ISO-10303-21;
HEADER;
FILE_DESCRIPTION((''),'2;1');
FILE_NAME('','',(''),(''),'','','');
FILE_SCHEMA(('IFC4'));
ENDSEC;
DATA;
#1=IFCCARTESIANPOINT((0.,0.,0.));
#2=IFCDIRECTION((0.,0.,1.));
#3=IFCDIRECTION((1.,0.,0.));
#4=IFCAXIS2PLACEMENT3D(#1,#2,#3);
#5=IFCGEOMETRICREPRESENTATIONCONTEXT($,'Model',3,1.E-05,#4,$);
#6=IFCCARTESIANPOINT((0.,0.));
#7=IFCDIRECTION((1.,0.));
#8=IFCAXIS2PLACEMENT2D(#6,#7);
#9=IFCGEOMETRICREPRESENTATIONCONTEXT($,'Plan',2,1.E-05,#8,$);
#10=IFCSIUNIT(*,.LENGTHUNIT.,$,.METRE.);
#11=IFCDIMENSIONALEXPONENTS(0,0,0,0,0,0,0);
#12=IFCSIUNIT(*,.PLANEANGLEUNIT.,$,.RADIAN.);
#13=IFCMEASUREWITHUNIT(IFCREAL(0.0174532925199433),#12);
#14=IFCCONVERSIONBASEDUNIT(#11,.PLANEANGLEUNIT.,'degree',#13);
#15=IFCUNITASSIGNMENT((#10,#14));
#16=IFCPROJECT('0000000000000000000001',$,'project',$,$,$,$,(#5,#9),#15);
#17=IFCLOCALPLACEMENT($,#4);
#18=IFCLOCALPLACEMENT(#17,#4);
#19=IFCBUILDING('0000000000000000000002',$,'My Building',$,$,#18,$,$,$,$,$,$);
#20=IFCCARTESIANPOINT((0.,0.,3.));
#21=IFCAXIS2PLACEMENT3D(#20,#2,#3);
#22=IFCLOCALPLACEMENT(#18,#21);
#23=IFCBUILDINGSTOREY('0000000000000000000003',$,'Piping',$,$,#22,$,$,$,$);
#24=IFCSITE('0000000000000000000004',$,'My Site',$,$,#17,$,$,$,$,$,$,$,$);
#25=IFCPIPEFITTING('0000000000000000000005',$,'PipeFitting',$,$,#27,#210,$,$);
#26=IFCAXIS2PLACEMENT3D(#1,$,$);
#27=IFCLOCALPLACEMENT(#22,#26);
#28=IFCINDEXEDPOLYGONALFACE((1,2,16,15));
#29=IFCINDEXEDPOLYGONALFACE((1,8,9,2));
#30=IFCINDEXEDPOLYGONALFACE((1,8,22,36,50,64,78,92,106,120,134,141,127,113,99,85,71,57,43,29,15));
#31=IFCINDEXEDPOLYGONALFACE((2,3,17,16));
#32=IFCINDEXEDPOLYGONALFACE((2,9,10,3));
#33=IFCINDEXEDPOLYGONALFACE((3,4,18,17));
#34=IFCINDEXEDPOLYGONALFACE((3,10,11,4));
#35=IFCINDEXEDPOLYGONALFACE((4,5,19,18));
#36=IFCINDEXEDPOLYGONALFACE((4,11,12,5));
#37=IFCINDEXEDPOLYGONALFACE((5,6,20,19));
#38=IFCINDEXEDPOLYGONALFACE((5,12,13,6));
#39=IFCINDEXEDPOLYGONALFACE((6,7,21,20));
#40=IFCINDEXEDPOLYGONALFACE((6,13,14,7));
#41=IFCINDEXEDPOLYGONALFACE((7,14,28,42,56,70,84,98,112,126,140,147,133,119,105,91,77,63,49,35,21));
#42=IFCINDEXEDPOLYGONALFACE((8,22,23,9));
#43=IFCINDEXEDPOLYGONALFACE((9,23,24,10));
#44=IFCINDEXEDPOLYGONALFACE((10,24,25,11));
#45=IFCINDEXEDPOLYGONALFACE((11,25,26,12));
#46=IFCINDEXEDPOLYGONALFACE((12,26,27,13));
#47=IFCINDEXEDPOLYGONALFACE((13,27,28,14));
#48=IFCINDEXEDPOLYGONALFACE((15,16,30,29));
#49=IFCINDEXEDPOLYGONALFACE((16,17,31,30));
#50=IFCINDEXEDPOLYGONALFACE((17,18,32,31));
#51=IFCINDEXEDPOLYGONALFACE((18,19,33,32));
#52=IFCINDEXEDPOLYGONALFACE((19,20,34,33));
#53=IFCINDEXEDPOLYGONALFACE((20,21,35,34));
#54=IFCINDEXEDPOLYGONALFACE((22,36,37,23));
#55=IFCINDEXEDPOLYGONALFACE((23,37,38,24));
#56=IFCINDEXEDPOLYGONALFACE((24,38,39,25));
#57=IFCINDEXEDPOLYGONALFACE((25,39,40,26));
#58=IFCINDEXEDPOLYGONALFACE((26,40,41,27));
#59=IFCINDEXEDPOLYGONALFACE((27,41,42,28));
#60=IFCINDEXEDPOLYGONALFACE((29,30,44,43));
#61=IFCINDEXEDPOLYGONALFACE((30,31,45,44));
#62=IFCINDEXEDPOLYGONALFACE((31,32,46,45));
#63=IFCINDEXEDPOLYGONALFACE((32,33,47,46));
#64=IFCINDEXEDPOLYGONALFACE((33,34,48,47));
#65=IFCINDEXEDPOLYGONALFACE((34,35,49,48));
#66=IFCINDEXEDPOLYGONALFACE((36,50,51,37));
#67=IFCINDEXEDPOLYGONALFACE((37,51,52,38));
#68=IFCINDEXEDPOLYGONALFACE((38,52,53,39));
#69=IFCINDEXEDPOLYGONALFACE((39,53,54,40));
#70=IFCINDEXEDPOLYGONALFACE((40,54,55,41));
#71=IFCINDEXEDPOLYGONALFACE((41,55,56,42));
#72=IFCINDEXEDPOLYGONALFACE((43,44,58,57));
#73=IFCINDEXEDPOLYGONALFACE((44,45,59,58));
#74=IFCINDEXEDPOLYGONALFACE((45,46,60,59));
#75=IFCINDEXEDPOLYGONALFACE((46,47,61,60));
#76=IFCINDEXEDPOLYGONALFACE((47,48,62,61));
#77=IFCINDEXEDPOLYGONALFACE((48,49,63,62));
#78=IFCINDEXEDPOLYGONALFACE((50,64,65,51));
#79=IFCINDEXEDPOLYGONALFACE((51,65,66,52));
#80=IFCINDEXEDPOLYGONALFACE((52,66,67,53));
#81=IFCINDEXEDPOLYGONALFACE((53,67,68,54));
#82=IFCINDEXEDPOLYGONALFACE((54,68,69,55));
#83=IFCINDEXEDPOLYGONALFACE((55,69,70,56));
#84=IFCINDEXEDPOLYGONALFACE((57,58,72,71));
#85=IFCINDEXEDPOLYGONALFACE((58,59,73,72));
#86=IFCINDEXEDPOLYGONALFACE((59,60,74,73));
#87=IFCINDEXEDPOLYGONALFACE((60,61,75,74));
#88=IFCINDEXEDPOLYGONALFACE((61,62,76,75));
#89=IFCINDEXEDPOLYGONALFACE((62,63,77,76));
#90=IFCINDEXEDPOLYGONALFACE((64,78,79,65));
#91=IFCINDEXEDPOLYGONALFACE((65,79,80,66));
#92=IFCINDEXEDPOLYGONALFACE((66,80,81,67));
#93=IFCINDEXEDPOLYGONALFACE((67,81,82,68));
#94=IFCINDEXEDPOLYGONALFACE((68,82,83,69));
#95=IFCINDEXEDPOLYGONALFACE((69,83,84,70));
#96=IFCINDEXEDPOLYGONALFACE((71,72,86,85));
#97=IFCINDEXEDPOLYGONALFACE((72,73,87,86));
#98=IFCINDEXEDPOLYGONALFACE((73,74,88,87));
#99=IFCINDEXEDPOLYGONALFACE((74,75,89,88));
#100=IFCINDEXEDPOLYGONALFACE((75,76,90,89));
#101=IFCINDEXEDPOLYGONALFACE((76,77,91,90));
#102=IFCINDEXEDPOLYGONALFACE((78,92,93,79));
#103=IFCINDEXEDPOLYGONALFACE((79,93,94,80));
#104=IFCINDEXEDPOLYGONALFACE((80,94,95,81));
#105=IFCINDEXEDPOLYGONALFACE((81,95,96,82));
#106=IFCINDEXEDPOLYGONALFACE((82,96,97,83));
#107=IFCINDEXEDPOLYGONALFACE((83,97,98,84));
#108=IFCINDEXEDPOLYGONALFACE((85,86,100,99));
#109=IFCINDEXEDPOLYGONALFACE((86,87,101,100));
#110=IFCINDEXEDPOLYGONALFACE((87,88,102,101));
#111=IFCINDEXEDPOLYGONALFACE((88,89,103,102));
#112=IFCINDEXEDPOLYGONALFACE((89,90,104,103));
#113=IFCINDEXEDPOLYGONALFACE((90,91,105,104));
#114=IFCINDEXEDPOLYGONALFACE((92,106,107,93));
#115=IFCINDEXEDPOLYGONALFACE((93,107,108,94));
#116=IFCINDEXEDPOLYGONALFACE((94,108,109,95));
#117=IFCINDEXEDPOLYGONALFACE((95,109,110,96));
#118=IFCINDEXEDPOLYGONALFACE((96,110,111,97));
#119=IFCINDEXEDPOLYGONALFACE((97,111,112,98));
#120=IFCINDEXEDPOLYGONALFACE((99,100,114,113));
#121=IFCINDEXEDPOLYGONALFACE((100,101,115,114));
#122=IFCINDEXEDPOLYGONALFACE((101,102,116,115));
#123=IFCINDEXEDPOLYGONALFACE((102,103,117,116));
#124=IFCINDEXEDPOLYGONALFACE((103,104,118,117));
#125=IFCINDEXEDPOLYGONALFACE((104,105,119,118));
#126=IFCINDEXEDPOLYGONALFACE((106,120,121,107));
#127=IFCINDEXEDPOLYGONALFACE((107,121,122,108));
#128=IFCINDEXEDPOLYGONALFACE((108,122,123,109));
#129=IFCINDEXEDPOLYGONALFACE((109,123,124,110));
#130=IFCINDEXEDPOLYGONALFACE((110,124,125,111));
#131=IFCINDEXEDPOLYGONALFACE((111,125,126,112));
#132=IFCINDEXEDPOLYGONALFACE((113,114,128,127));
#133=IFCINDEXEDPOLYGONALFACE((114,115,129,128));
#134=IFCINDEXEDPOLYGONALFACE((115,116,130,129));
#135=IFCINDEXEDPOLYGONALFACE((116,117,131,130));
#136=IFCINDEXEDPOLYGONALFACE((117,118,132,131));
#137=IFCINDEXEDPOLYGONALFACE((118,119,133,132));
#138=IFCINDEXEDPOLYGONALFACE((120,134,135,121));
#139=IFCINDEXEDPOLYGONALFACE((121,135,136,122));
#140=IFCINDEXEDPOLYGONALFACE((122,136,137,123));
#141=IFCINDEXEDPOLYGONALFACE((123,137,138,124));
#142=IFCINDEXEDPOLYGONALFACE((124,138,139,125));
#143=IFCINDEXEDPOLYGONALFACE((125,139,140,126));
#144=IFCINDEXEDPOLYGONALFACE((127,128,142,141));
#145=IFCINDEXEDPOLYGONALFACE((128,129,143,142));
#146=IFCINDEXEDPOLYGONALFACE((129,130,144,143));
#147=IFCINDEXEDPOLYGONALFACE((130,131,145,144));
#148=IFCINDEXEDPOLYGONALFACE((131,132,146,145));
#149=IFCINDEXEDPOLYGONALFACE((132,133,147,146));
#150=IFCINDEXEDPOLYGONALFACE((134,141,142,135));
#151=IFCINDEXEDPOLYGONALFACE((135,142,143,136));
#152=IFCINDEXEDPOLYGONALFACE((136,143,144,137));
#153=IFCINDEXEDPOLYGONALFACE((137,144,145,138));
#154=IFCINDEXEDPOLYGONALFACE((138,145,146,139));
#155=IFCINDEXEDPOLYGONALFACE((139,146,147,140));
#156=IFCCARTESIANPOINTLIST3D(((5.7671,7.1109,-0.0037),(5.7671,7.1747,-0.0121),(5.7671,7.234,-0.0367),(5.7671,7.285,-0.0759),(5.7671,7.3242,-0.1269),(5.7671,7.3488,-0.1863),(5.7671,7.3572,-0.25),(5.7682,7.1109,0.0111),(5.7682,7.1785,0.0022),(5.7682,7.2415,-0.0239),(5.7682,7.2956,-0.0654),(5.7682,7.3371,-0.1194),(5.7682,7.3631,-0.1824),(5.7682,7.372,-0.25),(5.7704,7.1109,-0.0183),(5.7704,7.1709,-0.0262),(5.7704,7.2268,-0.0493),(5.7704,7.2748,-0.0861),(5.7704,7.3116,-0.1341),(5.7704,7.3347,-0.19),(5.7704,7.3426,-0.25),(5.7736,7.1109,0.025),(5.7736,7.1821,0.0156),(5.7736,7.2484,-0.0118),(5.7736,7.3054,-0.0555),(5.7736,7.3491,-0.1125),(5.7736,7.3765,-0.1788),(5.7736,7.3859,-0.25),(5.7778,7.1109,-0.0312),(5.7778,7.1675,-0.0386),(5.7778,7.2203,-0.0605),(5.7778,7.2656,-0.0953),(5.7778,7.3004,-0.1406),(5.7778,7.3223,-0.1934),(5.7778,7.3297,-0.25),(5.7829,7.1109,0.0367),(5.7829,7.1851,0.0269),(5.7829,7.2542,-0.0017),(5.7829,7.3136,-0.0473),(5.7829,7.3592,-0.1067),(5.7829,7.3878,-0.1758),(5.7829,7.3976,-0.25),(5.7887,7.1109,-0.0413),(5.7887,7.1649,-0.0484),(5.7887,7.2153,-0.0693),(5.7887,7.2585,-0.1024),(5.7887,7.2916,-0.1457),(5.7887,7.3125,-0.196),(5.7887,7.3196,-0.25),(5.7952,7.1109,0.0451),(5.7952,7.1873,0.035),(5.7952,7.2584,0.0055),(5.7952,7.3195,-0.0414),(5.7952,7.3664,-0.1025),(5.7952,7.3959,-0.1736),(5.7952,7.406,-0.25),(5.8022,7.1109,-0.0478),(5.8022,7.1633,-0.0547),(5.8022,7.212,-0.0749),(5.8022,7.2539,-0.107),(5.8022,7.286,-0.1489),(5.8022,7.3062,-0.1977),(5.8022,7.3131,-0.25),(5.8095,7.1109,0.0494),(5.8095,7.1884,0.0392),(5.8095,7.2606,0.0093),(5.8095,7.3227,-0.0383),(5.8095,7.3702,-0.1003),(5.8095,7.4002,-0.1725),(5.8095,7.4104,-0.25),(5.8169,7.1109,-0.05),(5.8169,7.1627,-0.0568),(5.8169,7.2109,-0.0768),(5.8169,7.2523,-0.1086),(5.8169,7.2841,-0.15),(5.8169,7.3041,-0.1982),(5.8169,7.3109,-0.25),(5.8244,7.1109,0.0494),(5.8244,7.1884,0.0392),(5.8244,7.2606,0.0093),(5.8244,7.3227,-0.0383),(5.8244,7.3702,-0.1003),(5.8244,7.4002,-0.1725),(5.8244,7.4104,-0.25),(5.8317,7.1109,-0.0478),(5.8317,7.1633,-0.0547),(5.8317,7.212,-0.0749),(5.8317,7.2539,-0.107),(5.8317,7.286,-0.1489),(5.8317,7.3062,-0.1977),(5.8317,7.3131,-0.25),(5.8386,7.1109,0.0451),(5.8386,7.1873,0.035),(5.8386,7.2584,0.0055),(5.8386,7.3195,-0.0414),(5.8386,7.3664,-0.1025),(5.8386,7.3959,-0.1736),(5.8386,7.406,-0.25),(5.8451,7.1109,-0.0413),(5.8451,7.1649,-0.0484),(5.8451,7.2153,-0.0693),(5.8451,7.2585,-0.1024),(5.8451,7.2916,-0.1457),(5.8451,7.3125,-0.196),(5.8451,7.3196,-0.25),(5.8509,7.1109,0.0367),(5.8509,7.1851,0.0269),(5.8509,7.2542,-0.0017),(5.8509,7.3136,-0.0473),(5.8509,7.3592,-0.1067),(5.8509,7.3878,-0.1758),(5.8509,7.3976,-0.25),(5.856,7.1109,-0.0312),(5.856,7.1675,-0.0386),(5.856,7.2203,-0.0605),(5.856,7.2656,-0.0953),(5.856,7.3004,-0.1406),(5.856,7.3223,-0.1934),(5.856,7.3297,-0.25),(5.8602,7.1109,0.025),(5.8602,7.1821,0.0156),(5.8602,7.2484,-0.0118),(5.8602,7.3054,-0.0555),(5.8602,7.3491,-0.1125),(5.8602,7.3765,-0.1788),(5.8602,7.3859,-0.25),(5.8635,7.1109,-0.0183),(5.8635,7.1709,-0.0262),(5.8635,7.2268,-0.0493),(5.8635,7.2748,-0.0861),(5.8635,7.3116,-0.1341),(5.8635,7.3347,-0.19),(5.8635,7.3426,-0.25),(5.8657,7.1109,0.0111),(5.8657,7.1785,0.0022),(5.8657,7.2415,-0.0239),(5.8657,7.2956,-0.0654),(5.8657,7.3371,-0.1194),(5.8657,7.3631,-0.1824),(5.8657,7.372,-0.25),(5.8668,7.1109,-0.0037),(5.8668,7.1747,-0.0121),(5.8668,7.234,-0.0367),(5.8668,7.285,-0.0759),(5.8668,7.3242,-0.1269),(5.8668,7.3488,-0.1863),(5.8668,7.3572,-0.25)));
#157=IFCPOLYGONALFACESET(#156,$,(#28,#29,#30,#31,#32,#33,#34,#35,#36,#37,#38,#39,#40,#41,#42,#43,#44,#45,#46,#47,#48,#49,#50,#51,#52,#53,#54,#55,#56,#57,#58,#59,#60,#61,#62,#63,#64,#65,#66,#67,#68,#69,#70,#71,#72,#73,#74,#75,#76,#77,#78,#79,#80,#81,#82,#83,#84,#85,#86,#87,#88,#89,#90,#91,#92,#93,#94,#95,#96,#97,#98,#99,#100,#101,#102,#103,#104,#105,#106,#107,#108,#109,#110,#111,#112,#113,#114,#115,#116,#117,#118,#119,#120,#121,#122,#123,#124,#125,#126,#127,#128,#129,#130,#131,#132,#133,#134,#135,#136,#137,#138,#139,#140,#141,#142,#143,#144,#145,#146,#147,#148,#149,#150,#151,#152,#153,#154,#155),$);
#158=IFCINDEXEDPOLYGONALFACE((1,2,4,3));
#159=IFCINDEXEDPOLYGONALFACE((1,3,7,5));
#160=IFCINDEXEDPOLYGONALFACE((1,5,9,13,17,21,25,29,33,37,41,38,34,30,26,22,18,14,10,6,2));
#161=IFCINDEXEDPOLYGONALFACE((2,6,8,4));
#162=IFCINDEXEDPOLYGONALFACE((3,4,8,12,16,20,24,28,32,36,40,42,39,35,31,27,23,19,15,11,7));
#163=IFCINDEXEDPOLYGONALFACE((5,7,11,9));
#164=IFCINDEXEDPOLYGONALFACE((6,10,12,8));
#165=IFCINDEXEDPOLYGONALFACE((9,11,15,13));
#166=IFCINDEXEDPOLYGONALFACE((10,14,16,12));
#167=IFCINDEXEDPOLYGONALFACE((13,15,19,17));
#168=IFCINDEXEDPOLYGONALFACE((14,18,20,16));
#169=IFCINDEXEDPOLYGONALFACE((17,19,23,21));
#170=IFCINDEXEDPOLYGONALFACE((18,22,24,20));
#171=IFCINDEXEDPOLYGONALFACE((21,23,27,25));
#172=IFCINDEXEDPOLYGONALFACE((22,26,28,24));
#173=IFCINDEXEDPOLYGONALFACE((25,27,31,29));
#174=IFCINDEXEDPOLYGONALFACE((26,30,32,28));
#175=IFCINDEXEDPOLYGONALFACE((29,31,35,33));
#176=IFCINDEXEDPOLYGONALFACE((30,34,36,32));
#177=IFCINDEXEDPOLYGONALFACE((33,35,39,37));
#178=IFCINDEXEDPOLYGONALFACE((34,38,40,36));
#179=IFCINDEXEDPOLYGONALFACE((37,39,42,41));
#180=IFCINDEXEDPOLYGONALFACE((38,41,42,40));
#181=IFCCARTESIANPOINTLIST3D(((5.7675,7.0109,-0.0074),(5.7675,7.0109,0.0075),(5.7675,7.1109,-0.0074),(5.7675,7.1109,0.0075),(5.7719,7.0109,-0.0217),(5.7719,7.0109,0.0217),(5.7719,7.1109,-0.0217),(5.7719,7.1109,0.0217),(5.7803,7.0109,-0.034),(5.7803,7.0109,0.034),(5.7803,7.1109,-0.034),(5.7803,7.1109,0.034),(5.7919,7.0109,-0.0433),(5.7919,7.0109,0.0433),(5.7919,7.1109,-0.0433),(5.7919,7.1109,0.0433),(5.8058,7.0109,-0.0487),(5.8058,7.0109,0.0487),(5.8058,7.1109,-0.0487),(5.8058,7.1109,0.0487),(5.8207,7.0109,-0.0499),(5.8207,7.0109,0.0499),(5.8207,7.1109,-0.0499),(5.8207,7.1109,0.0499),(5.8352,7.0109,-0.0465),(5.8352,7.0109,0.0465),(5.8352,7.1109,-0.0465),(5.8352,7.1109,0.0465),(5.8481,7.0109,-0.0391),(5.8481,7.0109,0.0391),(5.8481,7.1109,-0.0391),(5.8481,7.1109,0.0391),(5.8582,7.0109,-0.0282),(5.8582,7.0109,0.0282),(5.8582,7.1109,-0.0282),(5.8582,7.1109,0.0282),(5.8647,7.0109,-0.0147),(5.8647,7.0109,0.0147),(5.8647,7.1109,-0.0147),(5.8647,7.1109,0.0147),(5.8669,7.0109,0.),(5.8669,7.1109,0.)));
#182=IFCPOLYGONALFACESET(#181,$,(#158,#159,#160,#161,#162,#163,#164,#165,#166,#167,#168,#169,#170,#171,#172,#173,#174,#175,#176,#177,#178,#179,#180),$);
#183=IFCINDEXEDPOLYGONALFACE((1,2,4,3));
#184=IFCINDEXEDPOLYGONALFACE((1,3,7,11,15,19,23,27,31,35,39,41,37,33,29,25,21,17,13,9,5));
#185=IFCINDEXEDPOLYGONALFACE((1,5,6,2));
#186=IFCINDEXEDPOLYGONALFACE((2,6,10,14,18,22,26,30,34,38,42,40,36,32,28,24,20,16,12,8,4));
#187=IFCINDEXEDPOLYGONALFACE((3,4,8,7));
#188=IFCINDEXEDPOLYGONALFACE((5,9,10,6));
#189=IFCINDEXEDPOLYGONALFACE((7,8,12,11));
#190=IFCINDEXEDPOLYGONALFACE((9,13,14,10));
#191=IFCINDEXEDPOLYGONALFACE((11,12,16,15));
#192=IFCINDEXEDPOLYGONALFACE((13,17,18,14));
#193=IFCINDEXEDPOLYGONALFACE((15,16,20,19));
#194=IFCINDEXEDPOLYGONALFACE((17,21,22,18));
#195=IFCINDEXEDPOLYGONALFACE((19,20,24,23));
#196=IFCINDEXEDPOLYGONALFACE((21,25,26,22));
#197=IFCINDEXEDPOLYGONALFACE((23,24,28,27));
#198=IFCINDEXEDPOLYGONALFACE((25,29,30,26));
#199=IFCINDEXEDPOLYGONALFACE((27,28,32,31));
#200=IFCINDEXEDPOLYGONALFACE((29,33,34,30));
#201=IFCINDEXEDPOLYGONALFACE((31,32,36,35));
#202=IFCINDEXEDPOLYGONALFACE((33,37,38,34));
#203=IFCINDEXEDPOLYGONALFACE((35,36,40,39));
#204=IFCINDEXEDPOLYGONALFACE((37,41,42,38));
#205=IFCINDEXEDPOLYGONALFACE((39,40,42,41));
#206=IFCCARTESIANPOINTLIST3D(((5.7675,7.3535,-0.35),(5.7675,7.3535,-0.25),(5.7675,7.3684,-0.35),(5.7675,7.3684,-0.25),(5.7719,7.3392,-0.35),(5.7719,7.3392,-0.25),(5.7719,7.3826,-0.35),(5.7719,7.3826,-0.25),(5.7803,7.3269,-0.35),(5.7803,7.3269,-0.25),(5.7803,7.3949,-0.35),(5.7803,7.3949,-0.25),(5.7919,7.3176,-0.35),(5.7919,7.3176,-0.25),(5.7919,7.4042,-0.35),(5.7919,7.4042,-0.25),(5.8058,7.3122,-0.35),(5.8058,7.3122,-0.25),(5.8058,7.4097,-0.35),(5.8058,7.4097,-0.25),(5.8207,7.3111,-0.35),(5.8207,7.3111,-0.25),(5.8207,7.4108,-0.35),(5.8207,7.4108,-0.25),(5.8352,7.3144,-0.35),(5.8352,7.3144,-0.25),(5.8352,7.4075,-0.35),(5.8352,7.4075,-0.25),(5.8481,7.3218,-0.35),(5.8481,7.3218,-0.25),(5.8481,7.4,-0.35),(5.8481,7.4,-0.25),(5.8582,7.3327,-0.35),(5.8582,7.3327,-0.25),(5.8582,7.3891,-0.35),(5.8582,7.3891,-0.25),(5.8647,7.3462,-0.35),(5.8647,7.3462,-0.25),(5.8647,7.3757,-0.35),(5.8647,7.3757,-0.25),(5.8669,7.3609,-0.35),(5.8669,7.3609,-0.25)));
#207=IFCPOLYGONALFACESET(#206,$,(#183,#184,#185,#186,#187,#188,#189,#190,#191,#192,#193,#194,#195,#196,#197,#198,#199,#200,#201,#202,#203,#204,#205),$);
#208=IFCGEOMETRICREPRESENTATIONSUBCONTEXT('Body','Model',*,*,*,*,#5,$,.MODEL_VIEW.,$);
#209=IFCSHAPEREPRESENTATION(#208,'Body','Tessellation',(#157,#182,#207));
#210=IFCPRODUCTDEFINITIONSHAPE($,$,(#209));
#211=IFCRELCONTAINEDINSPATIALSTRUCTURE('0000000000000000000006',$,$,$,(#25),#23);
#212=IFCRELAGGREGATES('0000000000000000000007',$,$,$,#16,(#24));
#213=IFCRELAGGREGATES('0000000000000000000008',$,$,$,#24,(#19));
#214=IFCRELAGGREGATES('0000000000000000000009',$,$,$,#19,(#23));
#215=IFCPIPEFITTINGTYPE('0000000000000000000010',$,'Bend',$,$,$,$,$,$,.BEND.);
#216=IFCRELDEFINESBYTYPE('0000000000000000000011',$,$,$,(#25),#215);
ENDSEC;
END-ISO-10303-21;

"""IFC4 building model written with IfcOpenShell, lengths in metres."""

from ifc_helpers import new_model, entity, si_unit, converted_unit, frame, origin_with_axes, origin_2d_with_axis, place, context, subcontext, project, spatial, circle, extrude, source, transform, mapped, type_object, type_shapes, element, save


model = new_model("IFC4")

# Units and contexts
model_context = context("Model", 3, precision=1e-05, world=origin_with_axes())
plan_context = context("Plan", 2, precision=1e-05, world=origin_2d_with_axis())
body_context = subcontext(model_context, "Body", "Model", "MODEL_VIEW")
ifc_project = project(units=[si_unit("LENGTHUNIT", "METRE"), converted_unit("PLANEANGLEUNIT", "degree", entity("IfcReal", 0.0174532925199433), si_unit("PLANEANGLEUNIT", "RADIAN"), dimensions=[0, 0, 0, 0, 0, 0, 0])], contexts=[model_context, plan_context])

# Site, building, storey
site_placement = place(None, origin_with_axes())
site = spatial("IfcSite", under=ifc_project, at=site_placement, Name="My Site")
building_placement = place(site_placement, origin_with_axes())
building = spatial("IfcBuilding", under=site, at=building_placement, Name="My Building")
storey_placement = place(building_placement, frame((0.0, 0.0, 3.0), z_axis=(0.0, 0.0, 1.0), x_axis=(1.0, 0.0, 0.0)))
storey = spatial("IfcBuildingStorey", under=building, at=storey_placement, Name="Piping")

# Pipe fitting
pipe_fitting_type = type_object("IfcPipeFittingType", Name="Bend", PredefinedType="BEND")
shared_shape = source(origin_with_axes(), body_context, "Body", "SolidModel", [
    entity("IfcSweptDiskSolid", entity("IfcIndexedPolyCurve", entity("IfcCartesianPointList3D", [[0.0, 0.0, -0.1], [0.0, -0.0732, -0.2768], [0.0, -0.25, -0.35]]), [entity("IfcArcIndex", [1, 2, 3])]), 0.05),
    extrude(circle(Radius=0.05), origin_with_axes(), (0.0, 0.0, -1.0), 0.1),
    extrude(circle(Radius=0.05), frame((0.0, -0.25, -0.35), z_axis=(0.0, -1.0, 0.0), x_axis=(1.0, 0.0, 0.0)), (0.0, 0.0, 1.0), 0.1),
])
type_shapes(pipe_fitting_type, [shared_shape])
for number, where, z_axis, x_axis, name in (
    (1, (5.8169, 7.0109, 0.0), (0.0, -1.0, 0.0), (1.0, 0.0, 0.0), "PipeFitting"),
):
    element("IfcPipeFitting", number, at=place(storey_placement, frame(where, z_axis=z_axis, x_axis=x_axis)), inside=storey, type_object=pipe_fitting_type, Name=name, context=body_context, shape_type="MappedRepresentation", body=[
        mapped(shared_shape, transform((0.0, 0.0, 0.0), x_axis=(1.0, 0.0, 0.0), y_axis=(0.0, 1.0, 0.0), z_axis=(0.0, 0.0, 1.0), scale=1.0)),
    ])

save(model, "model.ifc")
